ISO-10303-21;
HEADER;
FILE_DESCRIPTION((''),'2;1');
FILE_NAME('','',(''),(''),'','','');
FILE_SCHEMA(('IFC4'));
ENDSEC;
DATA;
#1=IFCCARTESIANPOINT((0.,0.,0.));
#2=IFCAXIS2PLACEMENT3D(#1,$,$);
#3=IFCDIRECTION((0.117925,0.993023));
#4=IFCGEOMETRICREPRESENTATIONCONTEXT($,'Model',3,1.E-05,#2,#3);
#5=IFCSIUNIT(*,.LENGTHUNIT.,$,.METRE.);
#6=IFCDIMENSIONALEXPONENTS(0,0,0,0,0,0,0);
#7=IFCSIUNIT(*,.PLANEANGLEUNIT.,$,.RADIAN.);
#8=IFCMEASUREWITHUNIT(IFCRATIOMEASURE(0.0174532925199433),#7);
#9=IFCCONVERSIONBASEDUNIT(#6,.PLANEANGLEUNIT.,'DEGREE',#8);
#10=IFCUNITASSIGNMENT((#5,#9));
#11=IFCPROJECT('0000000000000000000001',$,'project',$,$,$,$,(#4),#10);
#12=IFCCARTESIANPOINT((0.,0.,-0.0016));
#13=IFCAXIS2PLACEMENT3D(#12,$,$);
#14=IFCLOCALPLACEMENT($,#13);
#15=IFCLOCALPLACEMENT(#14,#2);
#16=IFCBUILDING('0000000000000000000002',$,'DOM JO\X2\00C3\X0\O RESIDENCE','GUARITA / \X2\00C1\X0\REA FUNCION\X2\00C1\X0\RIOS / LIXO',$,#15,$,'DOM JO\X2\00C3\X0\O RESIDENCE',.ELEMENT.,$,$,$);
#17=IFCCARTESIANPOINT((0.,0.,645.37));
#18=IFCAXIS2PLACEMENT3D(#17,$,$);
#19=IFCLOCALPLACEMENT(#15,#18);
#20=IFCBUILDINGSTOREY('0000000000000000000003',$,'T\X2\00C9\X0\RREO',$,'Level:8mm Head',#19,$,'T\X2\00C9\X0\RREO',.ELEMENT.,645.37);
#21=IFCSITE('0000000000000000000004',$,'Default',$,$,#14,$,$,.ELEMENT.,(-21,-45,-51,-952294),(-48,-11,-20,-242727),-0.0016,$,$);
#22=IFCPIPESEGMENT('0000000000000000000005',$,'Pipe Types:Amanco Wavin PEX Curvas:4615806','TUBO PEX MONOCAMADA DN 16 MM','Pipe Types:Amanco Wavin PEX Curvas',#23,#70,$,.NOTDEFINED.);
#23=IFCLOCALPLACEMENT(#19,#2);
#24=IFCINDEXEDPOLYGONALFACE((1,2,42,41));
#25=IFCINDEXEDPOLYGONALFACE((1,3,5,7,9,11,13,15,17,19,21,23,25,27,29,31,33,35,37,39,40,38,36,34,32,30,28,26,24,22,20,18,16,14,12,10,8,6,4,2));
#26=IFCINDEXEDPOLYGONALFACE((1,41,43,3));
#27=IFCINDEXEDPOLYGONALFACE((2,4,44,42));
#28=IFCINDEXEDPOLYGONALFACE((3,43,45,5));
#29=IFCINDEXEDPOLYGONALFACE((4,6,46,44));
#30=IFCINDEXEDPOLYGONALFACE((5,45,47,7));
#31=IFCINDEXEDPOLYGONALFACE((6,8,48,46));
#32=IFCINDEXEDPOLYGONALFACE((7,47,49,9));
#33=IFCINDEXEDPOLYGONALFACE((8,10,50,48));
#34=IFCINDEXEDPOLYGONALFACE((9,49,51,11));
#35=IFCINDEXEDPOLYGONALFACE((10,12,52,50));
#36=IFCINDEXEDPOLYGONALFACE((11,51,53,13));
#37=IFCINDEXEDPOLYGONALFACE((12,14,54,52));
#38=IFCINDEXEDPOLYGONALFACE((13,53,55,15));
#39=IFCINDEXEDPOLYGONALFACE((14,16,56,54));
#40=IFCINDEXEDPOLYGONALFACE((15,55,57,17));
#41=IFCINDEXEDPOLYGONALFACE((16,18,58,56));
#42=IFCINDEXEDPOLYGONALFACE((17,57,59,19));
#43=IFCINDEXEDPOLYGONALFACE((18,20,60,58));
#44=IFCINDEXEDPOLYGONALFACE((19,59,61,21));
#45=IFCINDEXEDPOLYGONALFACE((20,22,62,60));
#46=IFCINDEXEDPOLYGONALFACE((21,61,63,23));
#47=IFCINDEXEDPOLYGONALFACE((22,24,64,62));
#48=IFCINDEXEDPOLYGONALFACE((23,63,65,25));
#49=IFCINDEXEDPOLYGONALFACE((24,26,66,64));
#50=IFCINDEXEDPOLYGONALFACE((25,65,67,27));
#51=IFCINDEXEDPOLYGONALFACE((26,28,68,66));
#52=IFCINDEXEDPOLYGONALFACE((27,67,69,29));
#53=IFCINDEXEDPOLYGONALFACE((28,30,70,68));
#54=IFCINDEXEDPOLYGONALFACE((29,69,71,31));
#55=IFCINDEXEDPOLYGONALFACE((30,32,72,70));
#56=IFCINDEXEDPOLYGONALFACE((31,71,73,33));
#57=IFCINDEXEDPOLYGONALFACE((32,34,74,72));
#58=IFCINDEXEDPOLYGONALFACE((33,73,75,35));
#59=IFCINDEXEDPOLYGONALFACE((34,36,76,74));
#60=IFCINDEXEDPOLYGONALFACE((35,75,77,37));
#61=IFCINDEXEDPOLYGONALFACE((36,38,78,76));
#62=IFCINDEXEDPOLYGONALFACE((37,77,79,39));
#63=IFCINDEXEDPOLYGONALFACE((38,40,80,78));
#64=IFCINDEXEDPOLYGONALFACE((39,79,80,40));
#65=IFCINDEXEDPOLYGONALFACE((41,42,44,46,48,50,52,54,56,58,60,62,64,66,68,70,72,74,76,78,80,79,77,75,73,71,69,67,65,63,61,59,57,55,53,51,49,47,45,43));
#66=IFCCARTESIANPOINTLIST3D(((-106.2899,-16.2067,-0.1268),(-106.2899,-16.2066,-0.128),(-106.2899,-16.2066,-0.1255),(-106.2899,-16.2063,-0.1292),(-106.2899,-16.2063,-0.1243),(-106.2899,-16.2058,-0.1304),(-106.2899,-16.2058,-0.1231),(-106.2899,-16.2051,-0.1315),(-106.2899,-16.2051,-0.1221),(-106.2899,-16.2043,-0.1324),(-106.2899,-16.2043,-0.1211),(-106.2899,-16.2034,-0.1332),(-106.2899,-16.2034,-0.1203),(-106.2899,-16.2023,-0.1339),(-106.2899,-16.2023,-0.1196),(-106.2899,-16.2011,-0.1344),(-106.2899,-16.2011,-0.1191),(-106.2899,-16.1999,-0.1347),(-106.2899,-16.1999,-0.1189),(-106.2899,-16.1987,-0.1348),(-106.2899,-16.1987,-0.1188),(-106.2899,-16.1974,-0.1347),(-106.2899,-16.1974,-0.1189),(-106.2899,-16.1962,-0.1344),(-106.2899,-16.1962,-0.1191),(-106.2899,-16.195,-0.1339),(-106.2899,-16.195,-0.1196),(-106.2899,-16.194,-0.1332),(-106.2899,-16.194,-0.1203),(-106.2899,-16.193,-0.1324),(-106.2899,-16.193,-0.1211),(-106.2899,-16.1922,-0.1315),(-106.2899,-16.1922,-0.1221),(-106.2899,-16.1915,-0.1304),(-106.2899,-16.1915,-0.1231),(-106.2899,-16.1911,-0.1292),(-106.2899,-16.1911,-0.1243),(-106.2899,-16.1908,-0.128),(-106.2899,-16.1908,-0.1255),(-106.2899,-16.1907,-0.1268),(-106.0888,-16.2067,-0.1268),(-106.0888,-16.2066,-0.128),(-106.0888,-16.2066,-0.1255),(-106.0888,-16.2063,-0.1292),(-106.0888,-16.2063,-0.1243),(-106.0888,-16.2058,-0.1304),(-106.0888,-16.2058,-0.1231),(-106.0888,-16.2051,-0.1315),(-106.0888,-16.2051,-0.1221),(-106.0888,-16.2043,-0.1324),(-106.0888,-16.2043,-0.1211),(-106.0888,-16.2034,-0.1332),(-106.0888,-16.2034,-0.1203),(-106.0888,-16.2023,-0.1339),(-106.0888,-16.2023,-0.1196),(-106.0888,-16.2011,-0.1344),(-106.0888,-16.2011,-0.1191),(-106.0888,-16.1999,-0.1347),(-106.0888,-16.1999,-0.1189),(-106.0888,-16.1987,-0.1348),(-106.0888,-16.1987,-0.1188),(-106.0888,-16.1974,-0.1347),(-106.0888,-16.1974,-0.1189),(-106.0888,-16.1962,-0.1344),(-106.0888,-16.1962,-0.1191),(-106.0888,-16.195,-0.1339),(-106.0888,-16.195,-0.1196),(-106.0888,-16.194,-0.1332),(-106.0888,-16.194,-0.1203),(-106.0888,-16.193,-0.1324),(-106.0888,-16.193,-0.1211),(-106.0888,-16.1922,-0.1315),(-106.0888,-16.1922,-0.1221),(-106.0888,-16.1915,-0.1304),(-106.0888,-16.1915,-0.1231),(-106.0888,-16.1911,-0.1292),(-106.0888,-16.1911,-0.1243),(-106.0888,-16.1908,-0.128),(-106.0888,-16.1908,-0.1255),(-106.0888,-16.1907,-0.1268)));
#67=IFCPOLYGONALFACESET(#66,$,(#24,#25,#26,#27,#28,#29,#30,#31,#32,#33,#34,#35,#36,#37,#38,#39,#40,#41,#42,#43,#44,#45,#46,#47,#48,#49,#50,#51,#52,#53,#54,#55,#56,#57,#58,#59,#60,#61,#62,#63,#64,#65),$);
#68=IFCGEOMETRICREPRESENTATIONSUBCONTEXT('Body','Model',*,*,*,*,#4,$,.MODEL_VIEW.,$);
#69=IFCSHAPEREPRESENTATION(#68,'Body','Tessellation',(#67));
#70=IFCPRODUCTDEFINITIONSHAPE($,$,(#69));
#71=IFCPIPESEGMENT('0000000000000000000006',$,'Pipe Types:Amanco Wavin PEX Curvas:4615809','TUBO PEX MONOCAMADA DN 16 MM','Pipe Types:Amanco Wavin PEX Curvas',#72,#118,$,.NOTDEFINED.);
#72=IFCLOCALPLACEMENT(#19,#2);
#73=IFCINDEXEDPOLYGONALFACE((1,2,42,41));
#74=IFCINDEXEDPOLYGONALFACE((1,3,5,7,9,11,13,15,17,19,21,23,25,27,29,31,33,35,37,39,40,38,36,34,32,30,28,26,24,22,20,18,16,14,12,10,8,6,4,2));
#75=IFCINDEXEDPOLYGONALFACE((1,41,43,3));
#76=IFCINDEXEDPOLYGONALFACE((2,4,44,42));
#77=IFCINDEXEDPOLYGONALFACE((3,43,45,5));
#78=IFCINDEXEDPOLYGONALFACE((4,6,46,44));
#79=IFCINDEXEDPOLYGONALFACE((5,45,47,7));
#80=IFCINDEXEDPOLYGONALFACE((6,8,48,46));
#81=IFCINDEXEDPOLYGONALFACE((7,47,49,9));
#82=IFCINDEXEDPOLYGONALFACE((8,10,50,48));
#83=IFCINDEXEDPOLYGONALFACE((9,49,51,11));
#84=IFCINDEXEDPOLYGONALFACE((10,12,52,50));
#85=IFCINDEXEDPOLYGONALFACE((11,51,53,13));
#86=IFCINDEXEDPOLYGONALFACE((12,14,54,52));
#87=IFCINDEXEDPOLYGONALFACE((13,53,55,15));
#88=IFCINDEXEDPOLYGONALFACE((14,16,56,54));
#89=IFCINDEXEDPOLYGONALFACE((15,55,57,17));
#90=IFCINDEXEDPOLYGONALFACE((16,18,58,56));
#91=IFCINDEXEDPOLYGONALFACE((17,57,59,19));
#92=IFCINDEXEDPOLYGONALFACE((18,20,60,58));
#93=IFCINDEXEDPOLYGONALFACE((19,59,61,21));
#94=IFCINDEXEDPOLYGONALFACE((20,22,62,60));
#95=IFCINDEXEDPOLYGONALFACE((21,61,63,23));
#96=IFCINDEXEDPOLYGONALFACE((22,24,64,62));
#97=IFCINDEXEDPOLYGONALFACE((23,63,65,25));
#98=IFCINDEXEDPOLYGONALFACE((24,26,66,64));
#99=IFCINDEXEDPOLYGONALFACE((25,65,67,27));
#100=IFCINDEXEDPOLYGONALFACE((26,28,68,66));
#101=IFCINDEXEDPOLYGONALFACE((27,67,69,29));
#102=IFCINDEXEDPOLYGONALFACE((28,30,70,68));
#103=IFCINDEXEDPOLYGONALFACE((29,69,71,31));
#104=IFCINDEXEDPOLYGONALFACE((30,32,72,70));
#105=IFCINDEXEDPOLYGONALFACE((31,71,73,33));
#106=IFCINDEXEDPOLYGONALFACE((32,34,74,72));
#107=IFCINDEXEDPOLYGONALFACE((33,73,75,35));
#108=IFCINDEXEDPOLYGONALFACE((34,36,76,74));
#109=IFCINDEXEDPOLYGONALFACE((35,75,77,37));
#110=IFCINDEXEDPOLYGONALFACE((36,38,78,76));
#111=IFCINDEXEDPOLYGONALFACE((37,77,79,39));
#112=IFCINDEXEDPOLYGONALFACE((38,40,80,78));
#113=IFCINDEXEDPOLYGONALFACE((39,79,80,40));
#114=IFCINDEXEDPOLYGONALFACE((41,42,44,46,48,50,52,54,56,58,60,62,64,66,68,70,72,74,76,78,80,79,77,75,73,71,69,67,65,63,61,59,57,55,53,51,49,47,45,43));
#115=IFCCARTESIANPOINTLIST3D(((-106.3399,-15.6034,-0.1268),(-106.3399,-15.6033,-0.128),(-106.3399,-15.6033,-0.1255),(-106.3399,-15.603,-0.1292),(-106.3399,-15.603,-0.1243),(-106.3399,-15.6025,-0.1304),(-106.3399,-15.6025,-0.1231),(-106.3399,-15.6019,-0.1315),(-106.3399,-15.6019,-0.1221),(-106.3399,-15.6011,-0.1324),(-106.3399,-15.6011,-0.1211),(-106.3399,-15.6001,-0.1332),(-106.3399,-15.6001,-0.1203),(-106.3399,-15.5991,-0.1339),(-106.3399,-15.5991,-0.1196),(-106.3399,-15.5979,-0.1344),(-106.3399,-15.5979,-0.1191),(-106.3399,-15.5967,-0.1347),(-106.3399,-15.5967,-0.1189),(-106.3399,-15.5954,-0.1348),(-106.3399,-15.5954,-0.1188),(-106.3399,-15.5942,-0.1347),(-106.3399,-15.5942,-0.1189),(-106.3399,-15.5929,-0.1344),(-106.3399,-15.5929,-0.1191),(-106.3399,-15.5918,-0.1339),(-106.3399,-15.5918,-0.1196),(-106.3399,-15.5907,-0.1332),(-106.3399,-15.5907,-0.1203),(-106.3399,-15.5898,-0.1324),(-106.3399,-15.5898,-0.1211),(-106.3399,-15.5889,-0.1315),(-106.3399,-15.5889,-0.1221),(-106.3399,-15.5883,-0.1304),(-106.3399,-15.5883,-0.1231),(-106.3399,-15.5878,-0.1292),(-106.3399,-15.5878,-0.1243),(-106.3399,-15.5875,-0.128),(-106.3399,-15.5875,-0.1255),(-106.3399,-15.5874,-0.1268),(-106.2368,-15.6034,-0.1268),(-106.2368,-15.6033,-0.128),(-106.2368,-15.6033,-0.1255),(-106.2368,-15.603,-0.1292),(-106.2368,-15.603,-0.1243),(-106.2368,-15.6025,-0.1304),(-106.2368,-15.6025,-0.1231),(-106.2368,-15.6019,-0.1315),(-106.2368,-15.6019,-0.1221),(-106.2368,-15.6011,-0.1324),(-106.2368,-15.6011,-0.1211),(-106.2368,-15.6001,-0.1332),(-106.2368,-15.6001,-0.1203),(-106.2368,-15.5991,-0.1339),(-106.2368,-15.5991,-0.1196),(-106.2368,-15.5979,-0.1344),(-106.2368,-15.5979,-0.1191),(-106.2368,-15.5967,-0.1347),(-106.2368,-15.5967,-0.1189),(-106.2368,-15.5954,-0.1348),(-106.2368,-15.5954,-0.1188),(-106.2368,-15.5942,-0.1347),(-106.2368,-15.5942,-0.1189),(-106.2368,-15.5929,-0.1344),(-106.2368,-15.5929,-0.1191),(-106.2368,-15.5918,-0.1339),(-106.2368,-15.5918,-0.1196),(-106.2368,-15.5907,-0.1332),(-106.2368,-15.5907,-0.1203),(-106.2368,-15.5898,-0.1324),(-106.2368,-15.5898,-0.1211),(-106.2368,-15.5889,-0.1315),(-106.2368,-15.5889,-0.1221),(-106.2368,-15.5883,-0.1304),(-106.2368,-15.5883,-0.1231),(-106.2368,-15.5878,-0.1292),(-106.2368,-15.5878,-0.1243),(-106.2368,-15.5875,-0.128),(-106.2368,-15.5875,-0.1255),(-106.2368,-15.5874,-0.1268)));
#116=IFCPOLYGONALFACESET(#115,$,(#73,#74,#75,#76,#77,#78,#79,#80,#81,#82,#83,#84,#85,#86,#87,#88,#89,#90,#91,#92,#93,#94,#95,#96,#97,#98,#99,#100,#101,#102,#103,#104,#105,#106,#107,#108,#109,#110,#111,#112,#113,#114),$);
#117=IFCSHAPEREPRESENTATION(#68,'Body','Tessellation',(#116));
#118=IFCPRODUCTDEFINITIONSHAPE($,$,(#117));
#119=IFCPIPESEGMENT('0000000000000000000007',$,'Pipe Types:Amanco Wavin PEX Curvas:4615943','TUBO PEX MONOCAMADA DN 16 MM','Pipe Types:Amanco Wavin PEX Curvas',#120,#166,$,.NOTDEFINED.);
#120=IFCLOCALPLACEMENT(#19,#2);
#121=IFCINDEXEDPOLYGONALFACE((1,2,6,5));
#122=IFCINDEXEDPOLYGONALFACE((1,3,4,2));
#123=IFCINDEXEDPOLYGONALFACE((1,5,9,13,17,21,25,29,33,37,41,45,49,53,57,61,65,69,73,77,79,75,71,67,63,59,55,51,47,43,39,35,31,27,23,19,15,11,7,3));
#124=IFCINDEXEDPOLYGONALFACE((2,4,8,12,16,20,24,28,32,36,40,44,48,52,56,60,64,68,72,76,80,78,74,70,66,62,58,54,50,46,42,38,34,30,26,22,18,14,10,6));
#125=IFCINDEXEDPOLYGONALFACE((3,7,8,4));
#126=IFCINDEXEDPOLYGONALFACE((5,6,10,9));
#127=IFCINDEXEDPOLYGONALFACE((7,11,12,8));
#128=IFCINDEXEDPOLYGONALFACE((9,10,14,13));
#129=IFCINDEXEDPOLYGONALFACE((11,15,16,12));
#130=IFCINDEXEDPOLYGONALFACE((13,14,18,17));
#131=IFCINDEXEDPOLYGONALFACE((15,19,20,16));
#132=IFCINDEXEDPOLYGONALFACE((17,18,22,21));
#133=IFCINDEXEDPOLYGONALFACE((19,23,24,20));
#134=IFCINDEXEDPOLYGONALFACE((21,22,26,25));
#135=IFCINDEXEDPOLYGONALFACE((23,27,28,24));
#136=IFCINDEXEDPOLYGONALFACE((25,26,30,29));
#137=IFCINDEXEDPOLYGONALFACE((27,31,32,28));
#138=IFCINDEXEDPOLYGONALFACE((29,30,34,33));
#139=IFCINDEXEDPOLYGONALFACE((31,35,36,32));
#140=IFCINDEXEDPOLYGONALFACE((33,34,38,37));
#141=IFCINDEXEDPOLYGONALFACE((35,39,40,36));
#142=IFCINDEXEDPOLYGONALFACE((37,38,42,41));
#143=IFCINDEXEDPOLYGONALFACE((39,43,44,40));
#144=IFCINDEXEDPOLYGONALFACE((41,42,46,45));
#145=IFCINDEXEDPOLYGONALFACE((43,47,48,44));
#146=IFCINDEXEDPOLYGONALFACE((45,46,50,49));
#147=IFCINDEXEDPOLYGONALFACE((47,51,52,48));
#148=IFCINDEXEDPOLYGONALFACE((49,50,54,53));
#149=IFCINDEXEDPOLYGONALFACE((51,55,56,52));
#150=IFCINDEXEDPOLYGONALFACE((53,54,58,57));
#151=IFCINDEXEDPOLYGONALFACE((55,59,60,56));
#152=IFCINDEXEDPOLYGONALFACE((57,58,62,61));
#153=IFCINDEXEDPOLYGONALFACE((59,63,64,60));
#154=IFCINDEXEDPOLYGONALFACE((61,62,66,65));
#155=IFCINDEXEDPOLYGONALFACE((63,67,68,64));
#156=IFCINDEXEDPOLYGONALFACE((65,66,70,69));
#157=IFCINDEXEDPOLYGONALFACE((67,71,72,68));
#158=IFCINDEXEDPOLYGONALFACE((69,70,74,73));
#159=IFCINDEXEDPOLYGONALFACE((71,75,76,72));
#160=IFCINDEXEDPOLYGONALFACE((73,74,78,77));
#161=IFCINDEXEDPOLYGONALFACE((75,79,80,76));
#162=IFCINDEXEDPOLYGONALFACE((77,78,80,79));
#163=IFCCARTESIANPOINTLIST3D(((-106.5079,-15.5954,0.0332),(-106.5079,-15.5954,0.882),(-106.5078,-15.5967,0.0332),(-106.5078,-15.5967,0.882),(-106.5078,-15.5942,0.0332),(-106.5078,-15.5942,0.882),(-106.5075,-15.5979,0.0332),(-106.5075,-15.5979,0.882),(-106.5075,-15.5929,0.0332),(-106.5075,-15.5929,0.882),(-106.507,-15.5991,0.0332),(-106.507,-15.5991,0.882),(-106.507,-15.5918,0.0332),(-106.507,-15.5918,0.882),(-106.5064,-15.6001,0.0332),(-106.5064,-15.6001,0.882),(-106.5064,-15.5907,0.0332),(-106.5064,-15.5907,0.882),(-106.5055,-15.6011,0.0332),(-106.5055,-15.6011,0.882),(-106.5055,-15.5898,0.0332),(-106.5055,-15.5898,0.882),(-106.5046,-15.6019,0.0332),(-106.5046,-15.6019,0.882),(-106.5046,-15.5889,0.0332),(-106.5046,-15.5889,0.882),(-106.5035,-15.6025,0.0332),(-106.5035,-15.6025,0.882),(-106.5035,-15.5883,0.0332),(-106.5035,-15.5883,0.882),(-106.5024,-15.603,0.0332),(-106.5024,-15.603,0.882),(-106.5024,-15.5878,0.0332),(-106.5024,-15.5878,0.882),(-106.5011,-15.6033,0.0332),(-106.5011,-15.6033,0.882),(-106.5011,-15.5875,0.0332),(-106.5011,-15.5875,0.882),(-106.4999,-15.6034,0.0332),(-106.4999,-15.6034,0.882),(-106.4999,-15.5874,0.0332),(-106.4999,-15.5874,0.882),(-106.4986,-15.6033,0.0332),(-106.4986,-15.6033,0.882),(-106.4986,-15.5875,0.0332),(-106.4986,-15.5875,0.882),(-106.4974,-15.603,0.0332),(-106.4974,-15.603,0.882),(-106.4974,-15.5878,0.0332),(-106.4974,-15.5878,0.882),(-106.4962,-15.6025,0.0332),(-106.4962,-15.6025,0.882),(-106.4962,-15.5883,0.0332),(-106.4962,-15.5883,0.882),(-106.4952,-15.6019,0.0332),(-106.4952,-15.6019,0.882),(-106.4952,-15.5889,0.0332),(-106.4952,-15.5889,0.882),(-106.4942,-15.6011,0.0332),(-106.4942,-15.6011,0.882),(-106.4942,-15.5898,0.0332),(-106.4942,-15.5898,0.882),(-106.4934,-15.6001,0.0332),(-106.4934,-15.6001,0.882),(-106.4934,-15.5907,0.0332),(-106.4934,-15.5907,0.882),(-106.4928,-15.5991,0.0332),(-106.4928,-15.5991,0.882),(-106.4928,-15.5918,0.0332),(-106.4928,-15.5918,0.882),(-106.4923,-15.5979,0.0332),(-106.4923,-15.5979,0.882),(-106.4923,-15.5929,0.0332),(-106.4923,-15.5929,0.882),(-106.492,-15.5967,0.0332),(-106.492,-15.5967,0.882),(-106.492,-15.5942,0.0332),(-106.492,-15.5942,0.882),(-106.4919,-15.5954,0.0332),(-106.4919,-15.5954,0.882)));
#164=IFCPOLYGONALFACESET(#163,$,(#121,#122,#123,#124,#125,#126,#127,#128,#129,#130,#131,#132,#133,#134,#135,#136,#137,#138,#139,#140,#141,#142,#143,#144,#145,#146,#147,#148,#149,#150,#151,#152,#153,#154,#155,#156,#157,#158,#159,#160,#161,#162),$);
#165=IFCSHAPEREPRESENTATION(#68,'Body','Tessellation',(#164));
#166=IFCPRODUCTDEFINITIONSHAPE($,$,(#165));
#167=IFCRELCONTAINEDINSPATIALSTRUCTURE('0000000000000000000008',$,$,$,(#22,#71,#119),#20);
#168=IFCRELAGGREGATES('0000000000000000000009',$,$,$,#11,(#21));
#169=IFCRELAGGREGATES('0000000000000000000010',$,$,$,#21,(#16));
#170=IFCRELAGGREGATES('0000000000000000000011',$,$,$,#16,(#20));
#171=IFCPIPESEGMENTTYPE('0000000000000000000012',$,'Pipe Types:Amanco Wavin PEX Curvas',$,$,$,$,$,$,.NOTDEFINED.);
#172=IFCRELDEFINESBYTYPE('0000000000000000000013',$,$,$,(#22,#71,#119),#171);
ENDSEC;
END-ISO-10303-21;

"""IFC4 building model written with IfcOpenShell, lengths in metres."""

from ifc_helpers import new_model, entity, si_unit, converted_unit, direction, frame, origin, place, context, subcontext, project, spatial, indexed_curve, outline, extrude, type_object, element, save


model = new_model("IFC4")

# Units and contexts
model_context = context("Model", 3, precision=1e-05, world=origin(), true_north=direction((0.117925, 0.993023)))
body_context = subcontext(model_context, "Body", "Model", "MODEL_VIEW")
ifc_project = project(units=[si_unit("LENGTHUNIT", "METRE"), converted_unit("PLANEANGLEUNIT", "DEGREE", entity("IfcRatioMeasure", 0.0174532925199433), si_unit("PLANEANGLEUNIT", "RADIAN"), dimensions=[0, 0, 0, 0, 0, 0, 0])], contexts=[model_context])

# Site, building, storey
site_placement = place(None, frame((0.0, 0.0, -0.0016)))
site = spatial("IfcSite", under=ifc_project, at=site_placement, Name="Default", CompositionType="ELEMENT", RefLatitude=(-21, -45, -51, -952294), RefLongitude=(-48, -11, -20, -242727), RefElevation=-0.0016)
building_placement = place(site_placement, origin())
building = spatial("IfcBuilding", under=site, at=building_placement, Name="DOM JOÃO RESIDENCE", Description="GUARITA / ÁREA FUNCIONÁRIOS / LIXO", LongName="DOM JOÃO RESIDENCE", CompositionType="ELEMENT")
storey_placement = place(building_placement, frame((0.0, 0.0, 645.37)))
storey = spatial("IfcBuildingStorey", under=building, at=storey_placement, Name="TÉRREO", ObjectType="Level:8mm Head", LongName="TÉRREO", CompositionType="ELEMENT", Elevation=645.37)

# Pipe segments
pipe_segment_type_1 = type_object("IfcPipeSegmentType", Name="Pipe Types:Amanco Wavin PEX Curvas", PredefinedType="NOTDEFINED")
pipe_segment_1_placement = place(storey_placement, frame((-106.2899, -16.2083, -0.1364)))
element("IfcPipeSegment", 1, at=pipe_segment_1_placement, inside=storey, type_object=pipe_segment_type_1, Name="Pipe Types:Amanco Wavin PEX Curvas:4615806", Description="TUBO PEX MONOCAMADA DN 16 MM", ObjectType="Pipe Types:Amanco Wavin PEX Curvas", PredefinedType="NOTDEFINED", context=body_context, shape_type="SweptSolid", body=[
    extrude(outline(indexed_curve([(0.008, 0.0), (0.0079, 0.0013), (0.0076, 0.0025), (0.0071, 0.0036), (0.0065, 0.0047), (0.0057, 0.0057), (0.0047, 0.0065), (0.0036, 0.0071), (0.0025, 0.0076), (0.0013, 0.0079), (0.0, 0.008), (-0.0013, 0.0079), (-0.0025, 0.0076), (-0.0036, 0.0071), (-0.0047, 0.0065), (-0.0057, 0.0057), (-0.0065, 0.0047), (-0.0071, 0.0036), (-0.0076, 0.0025), (-0.0079, 0.0013), (-0.008, 0.0), (-0.0079, -0.0013), (-0.0076, -0.0025), (-0.0071, -0.0036), (-0.0065, -0.0047), (-0.0057, -0.0057), (-0.0047, -0.0065), (-0.0036, -0.0071), (-0.0025, -0.0076), (-0.0013, -0.0079), (0.0, -0.008), (0.0013, -0.0079), (0.0025, -0.0076), (0.0036, -0.0071), (0.0047, -0.0065), (0.0057, -0.0057), (0.0065, -0.0047), (0.0071, -0.0036), (0.0076, -0.0025), (0.0079, -0.0013), (0.008, 0.0)], self_intersect=False)), frame((0.0, 0.0096, 0.0096), z_axis=(1.0, 0.0, 0.0), x_axis=(0.0, -1.0, 0.0)), (0.0, 0.0, 1.0), 0.2011),
])
pipe_segment_2_placement = place(storey_placement, frame((-106.3399, -15.605, -0.1364)))
element("IfcPipeSegment", 2, at=pipe_segment_2_placement, inside=storey, type_object=pipe_segment_type_1, Name="Pipe Types:Amanco Wavin PEX Curvas:4615809", Description="TUBO PEX MONOCAMADA DN 16 MM", ObjectType="Pipe Types:Amanco Wavin PEX Curvas", PredefinedType="NOTDEFINED", context=body_context, shape_type="SweptSolid", body=[
    extrude(outline(indexed_curve([(0.008, 0.0), (0.0079, 0.0013), (0.0076, 0.0025), (0.0071, 0.0036), (0.0065, 0.0047), (0.0057, 0.0057), (0.0047, 0.0065), (0.0036, 0.0071), (0.0025, 0.0076), (0.0013, 0.0079), (0.0, 0.008), (-0.0013, 0.0079), (-0.0025, 0.0076), (-0.0036, 0.0071), (-0.0047, 0.0065), (-0.0057, 0.0057), (-0.0065, 0.0047), (-0.0071, 0.0036), (-0.0076, 0.0025), (-0.0079, 0.0013), (-0.008, 0.0), (-0.0079, -0.0013), (-0.0076, -0.0025), (-0.0071, -0.0036), (-0.0065, -0.0047), (-0.0057, -0.0057), (-0.0047, -0.0065), (-0.0036, -0.0071), (-0.0025, -0.0076), (-0.0013, -0.0079), (0.0, -0.008), (0.0013, -0.0079), (0.0025, -0.0076), (0.0036, -0.0071), (0.0047, -0.0065), (0.0057, -0.0057), (0.0065, -0.0047), (0.0071, -0.0036), (0.0076, -0.0025), (0.0079, -0.0013), (0.008, 0.0)], self_intersect=False)), frame((0.0, 0.0096, 0.0096), z_axis=(1.0, 0.0, 0.0), x_axis=(0.0, -1.0, 0.0)), (0.0, 0.0, 1.0), 0.1031),
])
pipe_segment_3_placement = place(storey_placement, frame((-106.5095, -15.605, 0.0332)))
element("IfcPipeSegment", 3, at=pipe_segment_3_placement, inside=storey, type_object=pipe_segment_type_1, Name="Pipe Types:Amanco Wavin PEX Curvas:4615943", Description="TUBO PEX MONOCAMADA DN 16 MM", ObjectType="Pipe Types:Amanco Wavin PEX Curvas", PredefinedType="NOTDEFINED", context=body_context, shape_type="SweptSolid", body=[
    extrude(outline(indexed_curve([(0.008, 0.0), (0.0079, 0.0013), (0.0076, 0.0025), (0.0071, 0.0036), (0.0065, 0.0047), (0.0057, 0.0057), (0.0047, 0.0065), (0.0036, 0.0071), (0.0025, 0.0076), (0.0013, 0.0079), (0.0, 0.008), (-0.0013, 0.0079), (-0.0025, 0.0076), (-0.0036, 0.0071), (-0.0047, 0.0065), (-0.0057, 0.0057), (-0.0065, 0.0047), (-0.0071, 0.0036), (-0.0076, 0.0025), (-0.0079, 0.0013), (-0.008, 0.0), (-0.0079, -0.0013), (-0.0076, -0.0025), (-0.0071, -0.0036), (-0.0065, -0.0047), (-0.0057, -0.0057), (-0.0047, -0.0065), (-0.0036, -0.0071), (-0.0025, -0.0076), (-0.0013, -0.0079), (0.0, -0.008), (0.0013, -0.0079), (0.0025, -0.0076), (0.0036, -0.0071), (0.0047, -0.0065), (0.0057, -0.0057), (0.0065, -0.0047), (0.0071, -0.0036), (0.0076, -0.0025), (0.0079, -0.0013), (0.008, 0.0)], self_intersect=False)), frame((0.0096, 0.0096, 0.0)), (0.0, 0.0, 1.0), 0.8488),
])

save(model, "model.ifc")
